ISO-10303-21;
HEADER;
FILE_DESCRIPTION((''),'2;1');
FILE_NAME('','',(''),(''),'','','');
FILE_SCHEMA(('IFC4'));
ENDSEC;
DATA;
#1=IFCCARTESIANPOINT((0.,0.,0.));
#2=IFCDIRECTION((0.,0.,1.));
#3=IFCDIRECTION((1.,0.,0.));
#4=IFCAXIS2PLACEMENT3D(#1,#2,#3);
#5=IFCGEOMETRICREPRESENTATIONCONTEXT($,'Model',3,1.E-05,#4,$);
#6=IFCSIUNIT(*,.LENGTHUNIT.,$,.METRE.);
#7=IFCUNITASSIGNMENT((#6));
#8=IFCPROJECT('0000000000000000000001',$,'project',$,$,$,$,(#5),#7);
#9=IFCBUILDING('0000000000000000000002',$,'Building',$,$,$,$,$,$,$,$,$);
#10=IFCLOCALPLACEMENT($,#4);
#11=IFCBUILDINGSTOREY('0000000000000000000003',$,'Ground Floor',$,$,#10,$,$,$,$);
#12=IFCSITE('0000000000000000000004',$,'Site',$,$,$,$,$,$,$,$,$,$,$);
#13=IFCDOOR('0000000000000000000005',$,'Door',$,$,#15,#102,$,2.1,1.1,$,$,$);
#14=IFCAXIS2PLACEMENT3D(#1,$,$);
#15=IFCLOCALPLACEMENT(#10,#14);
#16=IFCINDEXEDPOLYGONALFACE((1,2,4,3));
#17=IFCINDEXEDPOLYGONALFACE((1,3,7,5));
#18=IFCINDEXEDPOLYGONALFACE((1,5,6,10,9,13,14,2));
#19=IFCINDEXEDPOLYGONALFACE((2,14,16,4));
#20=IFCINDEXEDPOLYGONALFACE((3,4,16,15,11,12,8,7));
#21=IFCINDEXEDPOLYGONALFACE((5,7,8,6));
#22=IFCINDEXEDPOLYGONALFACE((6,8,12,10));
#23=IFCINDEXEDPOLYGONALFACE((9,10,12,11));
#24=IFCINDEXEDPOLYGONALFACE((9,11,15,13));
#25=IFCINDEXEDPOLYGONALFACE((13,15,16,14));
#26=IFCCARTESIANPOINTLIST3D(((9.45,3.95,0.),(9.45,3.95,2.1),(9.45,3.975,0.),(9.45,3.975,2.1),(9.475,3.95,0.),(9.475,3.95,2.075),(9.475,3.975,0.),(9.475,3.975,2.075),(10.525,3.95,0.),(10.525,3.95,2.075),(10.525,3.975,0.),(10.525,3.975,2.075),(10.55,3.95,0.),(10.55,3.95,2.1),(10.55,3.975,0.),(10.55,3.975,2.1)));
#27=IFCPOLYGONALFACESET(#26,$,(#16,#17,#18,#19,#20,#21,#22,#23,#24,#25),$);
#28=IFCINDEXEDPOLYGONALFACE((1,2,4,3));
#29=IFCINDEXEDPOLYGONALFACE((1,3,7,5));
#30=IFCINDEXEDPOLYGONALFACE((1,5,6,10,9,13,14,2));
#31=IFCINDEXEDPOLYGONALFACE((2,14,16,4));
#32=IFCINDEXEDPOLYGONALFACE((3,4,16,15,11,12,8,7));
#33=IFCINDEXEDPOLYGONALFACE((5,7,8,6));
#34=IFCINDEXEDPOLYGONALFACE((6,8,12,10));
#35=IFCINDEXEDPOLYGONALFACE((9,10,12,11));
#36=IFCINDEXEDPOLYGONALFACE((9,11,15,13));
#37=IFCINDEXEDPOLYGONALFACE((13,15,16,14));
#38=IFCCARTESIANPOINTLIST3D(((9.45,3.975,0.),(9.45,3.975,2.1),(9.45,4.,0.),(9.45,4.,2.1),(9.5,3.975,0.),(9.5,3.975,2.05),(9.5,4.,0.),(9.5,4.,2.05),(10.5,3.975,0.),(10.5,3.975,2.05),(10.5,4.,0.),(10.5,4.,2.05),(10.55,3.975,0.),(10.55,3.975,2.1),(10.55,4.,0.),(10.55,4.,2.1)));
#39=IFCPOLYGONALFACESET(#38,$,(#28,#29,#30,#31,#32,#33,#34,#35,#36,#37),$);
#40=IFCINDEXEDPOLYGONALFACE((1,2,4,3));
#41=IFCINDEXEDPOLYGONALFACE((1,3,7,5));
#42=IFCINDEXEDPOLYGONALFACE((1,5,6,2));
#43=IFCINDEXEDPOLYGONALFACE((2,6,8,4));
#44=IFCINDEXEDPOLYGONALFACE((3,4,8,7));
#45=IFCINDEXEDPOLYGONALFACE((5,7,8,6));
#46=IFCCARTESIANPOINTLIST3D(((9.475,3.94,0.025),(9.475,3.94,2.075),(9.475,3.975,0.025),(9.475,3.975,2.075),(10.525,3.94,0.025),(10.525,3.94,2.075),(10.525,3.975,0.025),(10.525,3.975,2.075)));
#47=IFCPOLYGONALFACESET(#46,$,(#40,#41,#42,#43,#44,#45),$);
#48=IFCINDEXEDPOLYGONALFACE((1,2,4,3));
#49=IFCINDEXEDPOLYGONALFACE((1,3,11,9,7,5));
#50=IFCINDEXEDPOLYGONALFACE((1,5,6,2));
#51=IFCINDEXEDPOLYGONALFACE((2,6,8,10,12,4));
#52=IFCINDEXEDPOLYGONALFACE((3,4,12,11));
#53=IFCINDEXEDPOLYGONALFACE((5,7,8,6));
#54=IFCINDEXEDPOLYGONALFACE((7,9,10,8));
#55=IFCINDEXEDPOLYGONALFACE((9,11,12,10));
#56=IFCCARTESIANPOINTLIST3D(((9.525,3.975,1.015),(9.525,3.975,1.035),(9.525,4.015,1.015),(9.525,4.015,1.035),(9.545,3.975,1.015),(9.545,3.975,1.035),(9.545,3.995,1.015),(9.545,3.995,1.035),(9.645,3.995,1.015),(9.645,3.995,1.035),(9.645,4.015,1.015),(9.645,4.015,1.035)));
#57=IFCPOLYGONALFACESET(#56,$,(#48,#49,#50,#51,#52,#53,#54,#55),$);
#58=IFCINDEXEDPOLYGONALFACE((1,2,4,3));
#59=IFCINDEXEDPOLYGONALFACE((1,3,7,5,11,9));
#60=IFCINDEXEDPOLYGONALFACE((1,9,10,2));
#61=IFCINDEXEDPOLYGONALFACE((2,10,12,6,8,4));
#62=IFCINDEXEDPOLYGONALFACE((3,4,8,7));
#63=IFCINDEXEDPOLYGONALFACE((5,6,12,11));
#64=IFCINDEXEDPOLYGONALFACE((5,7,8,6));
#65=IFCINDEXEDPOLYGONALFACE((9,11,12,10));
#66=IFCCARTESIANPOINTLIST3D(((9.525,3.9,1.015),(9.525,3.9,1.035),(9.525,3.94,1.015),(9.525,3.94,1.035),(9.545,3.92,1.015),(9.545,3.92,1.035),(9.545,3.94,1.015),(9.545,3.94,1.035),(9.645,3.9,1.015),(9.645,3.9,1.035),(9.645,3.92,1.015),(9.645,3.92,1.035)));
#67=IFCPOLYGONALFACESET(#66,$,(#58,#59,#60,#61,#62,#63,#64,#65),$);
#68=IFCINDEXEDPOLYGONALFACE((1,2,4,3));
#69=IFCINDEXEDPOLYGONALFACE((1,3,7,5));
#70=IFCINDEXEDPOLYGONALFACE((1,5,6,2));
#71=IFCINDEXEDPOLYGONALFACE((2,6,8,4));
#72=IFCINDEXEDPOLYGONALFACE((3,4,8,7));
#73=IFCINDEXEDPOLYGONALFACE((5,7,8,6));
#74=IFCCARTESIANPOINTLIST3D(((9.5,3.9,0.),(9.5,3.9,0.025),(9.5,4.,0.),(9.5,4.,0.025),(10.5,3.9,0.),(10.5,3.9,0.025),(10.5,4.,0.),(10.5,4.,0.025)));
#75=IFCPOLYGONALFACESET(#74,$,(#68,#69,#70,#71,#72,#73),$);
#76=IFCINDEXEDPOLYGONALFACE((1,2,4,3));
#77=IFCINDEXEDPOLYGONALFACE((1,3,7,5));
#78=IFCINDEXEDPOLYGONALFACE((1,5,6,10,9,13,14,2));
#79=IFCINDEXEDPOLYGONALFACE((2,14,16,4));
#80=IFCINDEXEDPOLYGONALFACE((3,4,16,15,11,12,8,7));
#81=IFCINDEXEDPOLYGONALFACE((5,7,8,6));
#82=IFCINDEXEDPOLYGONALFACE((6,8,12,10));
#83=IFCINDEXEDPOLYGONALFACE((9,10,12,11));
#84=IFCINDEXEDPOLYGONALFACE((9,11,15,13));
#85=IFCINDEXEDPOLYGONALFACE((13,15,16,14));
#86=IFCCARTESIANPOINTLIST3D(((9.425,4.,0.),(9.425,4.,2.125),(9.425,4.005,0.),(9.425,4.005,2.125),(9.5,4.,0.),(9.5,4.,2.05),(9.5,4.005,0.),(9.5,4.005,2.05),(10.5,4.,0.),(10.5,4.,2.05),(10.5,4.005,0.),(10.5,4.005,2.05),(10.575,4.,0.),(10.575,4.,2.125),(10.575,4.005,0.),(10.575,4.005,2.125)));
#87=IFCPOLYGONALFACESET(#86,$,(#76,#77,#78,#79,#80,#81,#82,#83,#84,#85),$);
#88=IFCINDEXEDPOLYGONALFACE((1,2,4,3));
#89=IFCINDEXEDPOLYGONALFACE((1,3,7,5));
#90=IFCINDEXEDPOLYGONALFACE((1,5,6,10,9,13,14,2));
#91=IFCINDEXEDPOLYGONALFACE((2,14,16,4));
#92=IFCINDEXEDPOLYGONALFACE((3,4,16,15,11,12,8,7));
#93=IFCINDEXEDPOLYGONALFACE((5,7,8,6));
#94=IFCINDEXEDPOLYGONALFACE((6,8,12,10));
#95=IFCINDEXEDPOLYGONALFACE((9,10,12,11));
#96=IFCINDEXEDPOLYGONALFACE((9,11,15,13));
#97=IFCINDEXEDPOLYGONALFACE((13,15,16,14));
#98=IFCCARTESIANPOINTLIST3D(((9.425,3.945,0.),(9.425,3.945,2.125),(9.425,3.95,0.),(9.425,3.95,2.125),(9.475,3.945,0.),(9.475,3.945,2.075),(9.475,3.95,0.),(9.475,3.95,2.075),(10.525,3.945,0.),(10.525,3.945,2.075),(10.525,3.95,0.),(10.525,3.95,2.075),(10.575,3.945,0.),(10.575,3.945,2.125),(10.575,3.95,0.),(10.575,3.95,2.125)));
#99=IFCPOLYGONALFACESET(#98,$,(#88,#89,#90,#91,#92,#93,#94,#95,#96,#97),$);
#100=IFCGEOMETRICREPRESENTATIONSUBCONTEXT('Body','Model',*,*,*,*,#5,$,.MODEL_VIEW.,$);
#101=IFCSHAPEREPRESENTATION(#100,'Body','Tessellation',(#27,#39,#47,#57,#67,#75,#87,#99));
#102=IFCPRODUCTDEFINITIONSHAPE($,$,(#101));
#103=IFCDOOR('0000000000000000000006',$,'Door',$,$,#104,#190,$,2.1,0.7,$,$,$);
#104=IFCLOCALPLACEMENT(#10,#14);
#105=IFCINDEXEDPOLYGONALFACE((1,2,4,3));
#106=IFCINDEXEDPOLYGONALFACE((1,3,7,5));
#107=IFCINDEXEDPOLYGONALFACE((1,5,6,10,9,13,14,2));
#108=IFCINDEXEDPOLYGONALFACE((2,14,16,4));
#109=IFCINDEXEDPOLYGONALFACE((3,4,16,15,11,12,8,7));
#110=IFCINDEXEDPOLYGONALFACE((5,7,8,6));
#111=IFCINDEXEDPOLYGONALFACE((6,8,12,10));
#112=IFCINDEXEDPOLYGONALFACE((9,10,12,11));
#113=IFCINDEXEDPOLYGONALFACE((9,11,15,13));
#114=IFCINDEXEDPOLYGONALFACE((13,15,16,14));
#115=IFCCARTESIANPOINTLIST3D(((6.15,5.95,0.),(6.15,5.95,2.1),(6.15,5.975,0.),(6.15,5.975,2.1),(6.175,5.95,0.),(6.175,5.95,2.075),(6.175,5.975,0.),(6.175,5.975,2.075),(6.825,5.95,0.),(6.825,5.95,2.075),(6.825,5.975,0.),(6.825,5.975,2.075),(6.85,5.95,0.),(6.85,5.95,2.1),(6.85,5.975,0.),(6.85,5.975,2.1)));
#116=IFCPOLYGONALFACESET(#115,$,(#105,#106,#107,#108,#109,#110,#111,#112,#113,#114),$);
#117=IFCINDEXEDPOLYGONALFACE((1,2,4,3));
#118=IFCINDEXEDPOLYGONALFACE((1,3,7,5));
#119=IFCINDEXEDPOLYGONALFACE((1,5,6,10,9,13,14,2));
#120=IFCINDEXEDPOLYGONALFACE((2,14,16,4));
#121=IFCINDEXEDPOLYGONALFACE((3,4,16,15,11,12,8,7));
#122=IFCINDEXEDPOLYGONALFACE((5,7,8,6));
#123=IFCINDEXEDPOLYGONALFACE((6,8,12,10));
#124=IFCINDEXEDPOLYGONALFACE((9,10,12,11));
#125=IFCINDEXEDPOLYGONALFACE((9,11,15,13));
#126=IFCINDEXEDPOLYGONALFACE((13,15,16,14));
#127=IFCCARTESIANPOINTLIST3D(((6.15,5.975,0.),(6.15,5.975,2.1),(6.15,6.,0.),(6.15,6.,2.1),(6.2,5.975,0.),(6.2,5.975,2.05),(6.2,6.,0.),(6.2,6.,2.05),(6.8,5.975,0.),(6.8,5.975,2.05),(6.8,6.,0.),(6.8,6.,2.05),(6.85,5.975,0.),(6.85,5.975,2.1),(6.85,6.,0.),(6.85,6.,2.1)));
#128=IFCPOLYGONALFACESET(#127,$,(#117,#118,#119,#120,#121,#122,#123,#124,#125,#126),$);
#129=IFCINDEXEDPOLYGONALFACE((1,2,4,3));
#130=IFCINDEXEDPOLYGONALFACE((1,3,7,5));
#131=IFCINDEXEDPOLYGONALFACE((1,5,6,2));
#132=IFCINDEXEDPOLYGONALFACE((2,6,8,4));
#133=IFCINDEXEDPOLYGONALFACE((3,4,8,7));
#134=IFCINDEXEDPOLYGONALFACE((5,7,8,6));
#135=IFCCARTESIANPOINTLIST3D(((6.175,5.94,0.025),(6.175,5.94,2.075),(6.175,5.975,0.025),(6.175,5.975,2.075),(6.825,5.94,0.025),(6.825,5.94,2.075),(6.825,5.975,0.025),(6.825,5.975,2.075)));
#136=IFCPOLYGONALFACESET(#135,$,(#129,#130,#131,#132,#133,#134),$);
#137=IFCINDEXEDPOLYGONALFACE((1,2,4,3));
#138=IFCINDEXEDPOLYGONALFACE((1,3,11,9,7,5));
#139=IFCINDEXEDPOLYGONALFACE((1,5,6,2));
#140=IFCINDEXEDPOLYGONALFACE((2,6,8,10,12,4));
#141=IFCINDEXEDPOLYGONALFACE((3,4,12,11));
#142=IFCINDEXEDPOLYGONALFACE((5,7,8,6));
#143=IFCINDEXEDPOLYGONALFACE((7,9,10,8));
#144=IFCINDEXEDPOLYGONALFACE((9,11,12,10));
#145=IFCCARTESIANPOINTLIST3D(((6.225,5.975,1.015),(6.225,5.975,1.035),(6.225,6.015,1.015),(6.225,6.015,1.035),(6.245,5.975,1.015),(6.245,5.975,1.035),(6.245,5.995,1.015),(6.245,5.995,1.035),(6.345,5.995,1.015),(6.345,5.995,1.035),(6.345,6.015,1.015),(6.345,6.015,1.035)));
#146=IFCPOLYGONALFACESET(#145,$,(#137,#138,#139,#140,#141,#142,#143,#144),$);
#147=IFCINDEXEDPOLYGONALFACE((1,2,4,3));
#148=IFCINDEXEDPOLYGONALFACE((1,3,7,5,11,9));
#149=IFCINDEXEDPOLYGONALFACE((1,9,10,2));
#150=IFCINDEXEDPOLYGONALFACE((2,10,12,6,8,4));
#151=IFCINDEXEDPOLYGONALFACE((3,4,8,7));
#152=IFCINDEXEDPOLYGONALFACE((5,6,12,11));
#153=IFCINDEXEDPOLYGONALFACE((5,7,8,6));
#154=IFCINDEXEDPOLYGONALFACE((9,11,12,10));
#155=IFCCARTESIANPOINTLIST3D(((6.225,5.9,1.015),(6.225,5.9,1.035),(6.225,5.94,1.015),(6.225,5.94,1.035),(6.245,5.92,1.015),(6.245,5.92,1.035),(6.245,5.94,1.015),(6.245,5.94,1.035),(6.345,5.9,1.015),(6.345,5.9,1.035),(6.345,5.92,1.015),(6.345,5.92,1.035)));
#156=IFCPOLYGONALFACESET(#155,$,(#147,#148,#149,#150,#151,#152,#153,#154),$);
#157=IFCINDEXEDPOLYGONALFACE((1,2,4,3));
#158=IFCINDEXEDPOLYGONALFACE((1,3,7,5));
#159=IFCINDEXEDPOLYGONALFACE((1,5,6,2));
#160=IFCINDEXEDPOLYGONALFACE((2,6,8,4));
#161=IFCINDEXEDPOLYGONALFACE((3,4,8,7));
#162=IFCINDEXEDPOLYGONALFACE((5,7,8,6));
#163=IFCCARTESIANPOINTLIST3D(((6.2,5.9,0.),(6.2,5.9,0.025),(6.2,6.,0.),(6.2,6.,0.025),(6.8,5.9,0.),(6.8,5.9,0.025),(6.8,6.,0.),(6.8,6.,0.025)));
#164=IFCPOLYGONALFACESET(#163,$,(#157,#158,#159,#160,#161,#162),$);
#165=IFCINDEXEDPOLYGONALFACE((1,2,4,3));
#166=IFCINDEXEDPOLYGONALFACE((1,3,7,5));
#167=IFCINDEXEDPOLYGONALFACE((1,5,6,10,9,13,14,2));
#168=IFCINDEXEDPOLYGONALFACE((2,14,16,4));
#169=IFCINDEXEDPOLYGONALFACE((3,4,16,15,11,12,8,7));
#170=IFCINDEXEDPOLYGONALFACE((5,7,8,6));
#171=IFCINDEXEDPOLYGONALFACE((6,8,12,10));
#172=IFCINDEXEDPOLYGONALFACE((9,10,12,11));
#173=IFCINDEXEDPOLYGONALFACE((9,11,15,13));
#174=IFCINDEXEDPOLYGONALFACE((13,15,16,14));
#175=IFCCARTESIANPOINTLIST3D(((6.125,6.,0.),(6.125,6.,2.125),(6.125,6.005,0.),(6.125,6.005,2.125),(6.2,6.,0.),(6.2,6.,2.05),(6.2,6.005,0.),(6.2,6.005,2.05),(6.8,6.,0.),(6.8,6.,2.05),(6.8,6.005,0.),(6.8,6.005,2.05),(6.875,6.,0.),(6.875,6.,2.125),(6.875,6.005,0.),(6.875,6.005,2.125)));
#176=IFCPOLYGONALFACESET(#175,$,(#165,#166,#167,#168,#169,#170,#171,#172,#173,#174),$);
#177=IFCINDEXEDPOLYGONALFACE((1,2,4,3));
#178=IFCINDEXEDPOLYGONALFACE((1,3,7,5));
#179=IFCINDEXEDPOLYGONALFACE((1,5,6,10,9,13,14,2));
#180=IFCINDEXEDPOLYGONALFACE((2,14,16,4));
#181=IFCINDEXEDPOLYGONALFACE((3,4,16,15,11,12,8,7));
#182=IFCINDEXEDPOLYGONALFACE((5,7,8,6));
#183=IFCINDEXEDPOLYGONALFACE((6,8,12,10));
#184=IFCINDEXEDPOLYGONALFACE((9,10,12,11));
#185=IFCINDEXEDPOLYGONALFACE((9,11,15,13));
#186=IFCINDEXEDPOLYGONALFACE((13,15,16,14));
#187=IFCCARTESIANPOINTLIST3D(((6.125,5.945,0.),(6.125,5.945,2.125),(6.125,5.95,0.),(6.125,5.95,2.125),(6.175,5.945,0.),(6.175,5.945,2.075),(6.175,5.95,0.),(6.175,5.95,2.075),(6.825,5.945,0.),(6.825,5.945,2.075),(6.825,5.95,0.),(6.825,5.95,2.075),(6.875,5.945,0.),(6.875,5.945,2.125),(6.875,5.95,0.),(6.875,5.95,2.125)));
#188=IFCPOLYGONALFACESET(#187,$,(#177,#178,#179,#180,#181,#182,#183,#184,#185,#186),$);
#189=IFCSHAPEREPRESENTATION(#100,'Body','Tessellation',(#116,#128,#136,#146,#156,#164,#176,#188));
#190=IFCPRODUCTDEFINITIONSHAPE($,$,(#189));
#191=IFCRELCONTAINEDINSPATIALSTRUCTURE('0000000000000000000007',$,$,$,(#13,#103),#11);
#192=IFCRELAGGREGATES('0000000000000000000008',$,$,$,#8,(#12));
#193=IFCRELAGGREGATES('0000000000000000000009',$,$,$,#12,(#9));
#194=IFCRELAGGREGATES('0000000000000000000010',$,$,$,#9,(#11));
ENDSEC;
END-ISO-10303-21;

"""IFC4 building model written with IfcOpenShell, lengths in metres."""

from ifc_helpers import new_model, si_unit, frame, origin_with_axes, place, context, subcontext, project, spatial, line, indexed_curve, outline, extrude, element, save


model = new_model("IFC4")

# Units and contexts
model_context = context("Model", 3, precision=1e-05, world=origin_with_axes())
body_context = subcontext(model_context, "Body", "Model", "MODEL_VIEW")
ifc_project = project(units=[si_unit("LENGTHUNIT", "METRE")], contexts=[model_context])

# Site, building, storey
site = spatial("IfcSite", under=ifc_project, Name="Site")
building = spatial("IfcBuilding", under=site, Name="Building")
storey_placement = place(None, origin_with_axes())
storey = spatial("IfcBuildingStorey", under=building, at=storey_placement, Name="Ground Floor")

# Doors
door_1_placement = place(storey_placement, frame((10.55, 4.0, 0.0), z_axis=(0.0, 0.0, 1.0), x_axis=(-1.0, 0.0, 0.0)))
element("IfcDoor", 1, at=door_1_placement, inside=storey, Name="Door", OverallHeight=2.1, OverallWidth=1.1, context=body_context, shape_type="SweptSolid", body=[
    extrude(outline(indexed_curve([(0.0, 0.0), (0.0, 2.1), (1.1, 2.1), (1.1, 0.0), (1.075, 0.0), (1.075, 2.075), (0.025, 2.075), (0.025, 0.0)], segments=[line(1, 2, 3, 4, 5, 6, 7, 8, 1)])), frame((0.0, 0.025, 0.0), z_axis=(0.0, -1.0, 0.0), x_axis=(1.0, 0.0, 0.0)), (0.0, 0.0, -1.0), 0.025),
    extrude(outline(indexed_curve([(0.0, 0.0), (0.0, 2.1), (1.1, 2.1), (1.1, 0.0), (1.05, 0.0), (1.05, 2.05), (0.05, 2.05), (0.05, 0.0)], segments=[line(1, 2, 3, 4, 5, 6, 7, 8, 1)])), frame((0.0, 0.0, 0.0), z_axis=(0.0, -1.0, 0.0), x_axis=(1.0, 0.0, 0.0)), (0.0, 0.0, -1.0), 0.025),
    extrude(outline(indexed_curve([(0.0, 0.0), (1.05, 0.0), (1.05, 0.035), (0.0, 0.035)], segments=[line(1, 2, 3, 4, 1)])), frame((0.025, 0.025, 0.025), z_axis=(0.0, 0.0, 1.0), x_axis=(1.0, 0.0, 0.0)), (0.0, 0.0, 1.0), 2.05),
    extrude(outline(indexed_curve([(0.0, 0.0), (0.0, -0.04), (-0.12, -0.04), (-0.12, -0.02), (-0.02, -0.02), (-0.02, 0.0)], segments=[line(1, 2, 3, 4, 5, 6, 1)])), frame((1.025, 0.025, 1.015), z_axis=(0.0, 0.0, 1.0), x_axis=(1.0, 0.0, 0.0)), (0.0, 0.0, 1.0), 0.02),
    extrude(outline(indexed_curve([(0.0, 0.0), (0.0, 0.04), (-0.12, 0.04), (-0.12, 0.02), (-0.02, 0.02), (-0.02, 0.0)], segments=[line(1, 2, 3, 4, 5, 6, 1)])), frame((1.025, 0.06, 1.015), z_axis=(0.0, 0.0, 1.0), x_axis=(1.0, 0.0, 0.0)), (0.0, 0.0, 1.0), 0.02),
    extrude(outline(indexed_curve([(0.0, 0.0), (1.0, 0.0), (1.0, 0.1), (0.0, 0.1)], segments=[line(1, 2, 3, 4, 1)])), frame((0.05, 0.0, 0.0), z_axis=(0.0, 0.0, 1.0), x_axis=(1.0, 0.0, 0.0)), (0.0, 0.0, 1.0), 0.025),
    extrude(outline(indexed_curve([(0.0, 0.0), (0.0, 2.125), (1.15, 2.125), (1.15, 0.0), (1.075, 0.0), (1.075, 2.05), (0.075, 2.05), (0.075, 0.0)], segments=[line(1, 2, 3, 4, 5, 6, 7, 8, 1)])), frame((-0.025, -0.005, 0.0), z_axis=(0.0, -1.0, 0.0), x_axis=(1.0, 0.0, 0.0)), (0.0, 0.0, -1.0), 0.005),
    extrude(outline(indexed_curve([(0.0, 0.0), (0.0, 2.125), (1.15, 2.125), (1.15, 0.0), (1.1, 0.0), (1.1, 2.075), (0.05, 2.075), (0.05, 0.0)], segments=[line(1, 2, 3, 4, 5, 6, 7, 8, 1)])), frame((-0.025, 0.05, 0.0), z_axis=(0.0, -1.0, 0.0), x_axis=(1.0, 0.0, 0.0)), (0.0, 0.0, -1.0), 0.005),
])
door_2_placement = place(storey_placement, frame((6.85, 6.0, 0.0), z_axis=(0.0, 0.0, 1.0), x_axis=(-1.0, 0.0, 0.0)))
element("IfcDoor", 2, at=door_2_placement, inside=storey, Name="Door", OverallHeight=2.1, OverallWidth=0.7, context=body_context, shape_type="SweptSolid", body=[
    extrude(outline(indexed_curve([(0.0, 0.0), (0.0, 2.1), (0.7, 2.1), (0.7, 0.0), (0.675, 0.0), (0.675, 2.075), (0.025, 2.075), (0.025, 0.0)], segments=[line(1, 2, 3, 4, 5, 6, 7, 8, 1)])), frame((0.0, 0.025, 0.0), z_axis=(0.0, -1.0, 0.0), x_axis=(1.0, 0.0, 0.0)), (0.0, 0.0, -1.0), 0.025),
    extrude(outline(indexed_curve([(0.0, 0.0), (0.0, 2.1), (0.7, 2.1), (0.7, 0.0), (0.65, 0.0), (0.65, 2.05), (0.05, 2.05), (0.05, 0.0)], segments=[line(1, 2, 3, 4, 5, 6, 7, 8, 1)])), frame((0.0, 0.0, 0.0), z_axis=(0.0, -1.0, 0.0), x_axis=(1.0, 0.0, 0.0)), (0.0, 0.0, -1.0), 0.025),
    extrude(outline(indexed_curve([(0.0, 0.0), (0.65, 0.0), (0.65, 0.035), (0.0, 0.035)], segments=[line(1, 2, 3, 4, 1)])), frame((0.025, 0.025, 0.025), z_axis=(0.0, 0.0, 1.0), x_axis=(1.0, 0.0, 0.0)), (0.0, 0.0, 1.0), 2.05),
    extrude(outline(indexed_curve([(0.0, 0.0), (0.0, -0.04), (-0.12, -0.04), (-0.12, -0.02), (-0.02, -0.02), (-0.02, 0.0)], segments=[line(1, 2, 3, 4, 5, 6, 1)])), frame((0.625, 0.025, 1.015), z_axis=(0.0, 0.0, 1.0), x_axis=(1.0, 0.0, 0.0)), (0.0, 0.0, 1.0), 0.02),
    extrude(outline(indexed_curve([(0.0, 0.0), (0.0, 0.04), (-0.12, 0.04), (-0.12, 0.02), (-0.02, 0.02), (-0.02, 0.0)], segments=[line(1, 2, 3, 4, 5, 6, 1)])), frame((0.625, 0.06, 1.015), z_axis=(0.0, 0.0, 1.0), x_axis=(1.0, 0.0, 0.0)), (0.0, 0.0, 1.0), 0.02),
    extrude(outline(indexed_curve([(0.0, 0.0), (0.6, 0.0), (0.6, 0.1), (0.0, 0.1)], segments=[line(1, 2, 3, 4, 1)])), frame((0.05, 0.0, 0.0), z_axis=(0.0, 0.0, 1.0), x_axis=(1.0, 0.0, 0.0)), (0.0, 0.0, 1.0), 0.025),
    extrude(outline(indexed_curve([(0.0, 0.0), (0.0, 2.125), (0.75, 2.125), (0.75, 0.0), (0.675, 0.0), (0.675, 2.05), (0.075, 2.05), (0.075, 0.0)], segments=[line(1, 2, 3, 4, 5, 6, 7, 8, 1)])), frame((-0.025, -0.005, 0.0), z_axis=(0.0, -1.0, 0.0), x_axis=(1.0, 0.0, 0.0)), (0.0, 0.0, -1.0), 0.005),
    extrude(outline(indexed_curve([(0.0, 0.0), (0.0, 2.125), (0.75, 2.125), (0.75, 0.0), (0.7, 0.0), (0.7, 2.075), (0.05, 2.075), (0.05, 0.0)], segments=[line(1, 2, 3, 4, 5, 6, 7, 8, 1)])), frame((-0.025, 0.05, 0.0), z_axis=(0.0, -1.0, 0.0), x_axis=(1.0, 0.0, 0.0)), (0.0, 0.0, -1.0), 0.005),
])

save(model, "model.ifc")
